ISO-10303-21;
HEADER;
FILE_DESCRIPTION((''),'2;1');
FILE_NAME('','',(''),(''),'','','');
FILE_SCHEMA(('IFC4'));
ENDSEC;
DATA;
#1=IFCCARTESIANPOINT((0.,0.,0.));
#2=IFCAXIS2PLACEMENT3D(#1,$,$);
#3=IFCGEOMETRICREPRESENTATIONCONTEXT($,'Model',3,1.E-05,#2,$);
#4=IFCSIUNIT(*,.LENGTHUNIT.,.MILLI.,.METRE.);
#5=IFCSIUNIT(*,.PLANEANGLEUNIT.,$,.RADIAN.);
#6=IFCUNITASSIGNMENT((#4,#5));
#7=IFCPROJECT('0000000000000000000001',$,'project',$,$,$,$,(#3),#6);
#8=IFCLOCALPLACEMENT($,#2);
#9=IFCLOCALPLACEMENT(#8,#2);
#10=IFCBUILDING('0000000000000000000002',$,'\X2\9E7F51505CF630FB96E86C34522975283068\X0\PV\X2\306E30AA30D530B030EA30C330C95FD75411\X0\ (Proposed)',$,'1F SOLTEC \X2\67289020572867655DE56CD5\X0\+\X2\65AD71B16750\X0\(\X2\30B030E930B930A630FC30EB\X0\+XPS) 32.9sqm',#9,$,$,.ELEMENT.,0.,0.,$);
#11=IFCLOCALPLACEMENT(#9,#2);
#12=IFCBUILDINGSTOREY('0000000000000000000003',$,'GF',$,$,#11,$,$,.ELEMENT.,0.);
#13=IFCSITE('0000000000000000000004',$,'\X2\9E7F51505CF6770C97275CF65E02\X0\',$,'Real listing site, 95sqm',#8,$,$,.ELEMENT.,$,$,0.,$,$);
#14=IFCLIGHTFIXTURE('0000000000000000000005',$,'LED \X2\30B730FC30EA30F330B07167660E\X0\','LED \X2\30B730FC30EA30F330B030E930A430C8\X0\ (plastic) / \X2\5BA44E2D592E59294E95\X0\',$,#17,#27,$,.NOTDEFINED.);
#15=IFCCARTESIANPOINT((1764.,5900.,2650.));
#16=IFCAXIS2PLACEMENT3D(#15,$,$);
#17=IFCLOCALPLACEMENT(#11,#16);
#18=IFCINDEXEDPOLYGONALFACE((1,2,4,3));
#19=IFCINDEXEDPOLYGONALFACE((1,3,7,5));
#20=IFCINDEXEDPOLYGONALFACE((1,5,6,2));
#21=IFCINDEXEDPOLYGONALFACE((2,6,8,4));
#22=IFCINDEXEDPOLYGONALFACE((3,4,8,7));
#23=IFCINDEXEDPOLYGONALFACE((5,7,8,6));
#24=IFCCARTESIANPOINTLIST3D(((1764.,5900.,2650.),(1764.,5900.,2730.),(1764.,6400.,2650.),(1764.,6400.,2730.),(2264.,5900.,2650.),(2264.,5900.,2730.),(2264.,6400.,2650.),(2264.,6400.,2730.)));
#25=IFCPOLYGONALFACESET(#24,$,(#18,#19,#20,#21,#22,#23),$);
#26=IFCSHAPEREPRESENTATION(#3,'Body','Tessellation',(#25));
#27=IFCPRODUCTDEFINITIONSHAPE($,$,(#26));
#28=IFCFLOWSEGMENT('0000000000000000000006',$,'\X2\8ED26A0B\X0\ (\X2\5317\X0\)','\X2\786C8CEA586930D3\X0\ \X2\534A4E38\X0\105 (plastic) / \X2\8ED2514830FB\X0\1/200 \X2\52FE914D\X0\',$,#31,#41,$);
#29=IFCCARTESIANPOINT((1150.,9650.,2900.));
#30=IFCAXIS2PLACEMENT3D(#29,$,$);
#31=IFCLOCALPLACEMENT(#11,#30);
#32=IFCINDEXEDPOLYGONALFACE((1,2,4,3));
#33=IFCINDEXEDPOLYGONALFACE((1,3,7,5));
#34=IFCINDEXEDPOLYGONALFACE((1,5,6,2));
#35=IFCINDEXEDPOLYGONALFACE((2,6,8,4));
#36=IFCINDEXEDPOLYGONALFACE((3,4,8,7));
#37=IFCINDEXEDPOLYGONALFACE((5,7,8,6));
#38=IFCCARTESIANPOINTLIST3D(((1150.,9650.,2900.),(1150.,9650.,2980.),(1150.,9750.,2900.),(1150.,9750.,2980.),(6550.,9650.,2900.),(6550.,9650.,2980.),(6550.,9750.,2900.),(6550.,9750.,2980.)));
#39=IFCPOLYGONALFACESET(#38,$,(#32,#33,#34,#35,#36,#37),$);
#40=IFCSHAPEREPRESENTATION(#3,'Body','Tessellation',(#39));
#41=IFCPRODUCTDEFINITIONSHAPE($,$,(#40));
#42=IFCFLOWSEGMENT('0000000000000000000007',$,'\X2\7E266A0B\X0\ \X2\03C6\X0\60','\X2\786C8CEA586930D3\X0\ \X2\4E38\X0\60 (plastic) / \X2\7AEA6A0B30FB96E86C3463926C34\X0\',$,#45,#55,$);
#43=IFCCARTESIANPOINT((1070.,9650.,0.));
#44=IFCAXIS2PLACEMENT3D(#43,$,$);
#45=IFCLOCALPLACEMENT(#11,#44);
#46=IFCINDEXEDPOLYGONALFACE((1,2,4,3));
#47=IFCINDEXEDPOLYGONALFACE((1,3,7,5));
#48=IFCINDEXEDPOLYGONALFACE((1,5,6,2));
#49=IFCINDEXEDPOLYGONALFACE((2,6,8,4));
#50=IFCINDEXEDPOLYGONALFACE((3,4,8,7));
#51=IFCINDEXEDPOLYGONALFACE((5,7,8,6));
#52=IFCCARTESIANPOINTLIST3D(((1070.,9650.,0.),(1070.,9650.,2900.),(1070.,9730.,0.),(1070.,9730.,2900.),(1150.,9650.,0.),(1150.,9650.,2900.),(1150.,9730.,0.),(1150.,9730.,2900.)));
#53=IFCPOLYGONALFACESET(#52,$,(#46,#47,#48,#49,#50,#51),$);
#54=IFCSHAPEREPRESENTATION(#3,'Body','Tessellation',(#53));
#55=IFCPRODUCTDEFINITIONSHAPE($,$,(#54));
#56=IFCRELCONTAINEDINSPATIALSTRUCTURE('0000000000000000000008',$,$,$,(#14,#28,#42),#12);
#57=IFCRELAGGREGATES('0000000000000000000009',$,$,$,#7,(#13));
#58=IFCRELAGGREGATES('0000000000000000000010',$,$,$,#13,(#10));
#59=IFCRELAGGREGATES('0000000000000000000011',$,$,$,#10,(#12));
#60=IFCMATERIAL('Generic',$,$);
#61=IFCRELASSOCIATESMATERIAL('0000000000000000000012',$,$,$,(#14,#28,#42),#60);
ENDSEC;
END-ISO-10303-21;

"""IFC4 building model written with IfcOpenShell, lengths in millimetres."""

from ifc_helpers import new_model, si_unit, frame, frame_2d, origin, place, context, project, spatial, rectangle, extrude, material, element, save


model = new_model("IFC4")

# Units and contexts
model_context = context("Model", 3, precision=1e-05, world=origin())
ifc_project = project(units=[si_unit("LENGTHUNIT", "METRE", prefix="MILLI"), si_unit("PLANEANGLEUNIT", "RADIAN")], contexts=[model_context])

# Site, building, storey
site_placement = place(None, origin())
site = spatial("IfcSite", under=ifc_project, at=site_placement, Name="鹿児島県霧島市", ObjectType="Real listing site, 95sqm", CompositionType="ELEMENT", RefElevation=0.0)
building_placement = place(site_placement, origin())
building = spatial("IfcBuilding", under=site, at=building_placement, Name="鹿児島・雨水利用とPVのオフグリッド志向 (Proposed)", ObjectType="1F SOLTEC 木造在来工法+断熱材(グラスウール+XPS) 32.9sqm", CompositionType="ELEMENT", ElevationOfRefHeight=0.0, ElevationOfTerrain=0.0)
storey_placement = place(building_placement, origin())
storey = spatial("IfcBuildingStorey", under=building, at=storey_placement, Name="GF", CompositionType="ELEMENT", Elevation=0.0)

# Shared definitions
ifc_material_1 = material(Name="Generic")

# Light fixture
light_fixture_placement = place(storey_placement, frame((1764.0, 5900.0, 2650.0)))
element("IfcLightFixture", 1, at=light_fixture_placement, inside=storey, material=ifc_material_1, Name="LED シーリング照明", Description="LED シーリングライト (plastic) / 室中央天井", PredefinedType="NOTDEFINED", context=model_context, shape_type="SweptSolid", body=[
    extrude(rectangle(XDim=500.0, YDim=500.0, at=frame_2d((250.0, 250.0))), frame((1764.0, 5900.0, 2650.0)), (0.0, 0.0, 1.0), 80.0),
])

# Flow segments
flow_segment_1_placement = place(storey_placement, frame((1150.0, 9650.0, 2900.0)))
element("IfcFlowSegment", 2, at=flow_segment_1_placement, inside=storey, material=ifc_material_1, Name="軒樋 (北)", Description="硬質塩ビ 半丸105 (plastic) / 軒先・1/200 勾配", context=model_context, shape_type="SweptSolid", body=[
    extrude(rectangle(XDim=5400.0, YDim=100.0, at=frame_2d((2700.0, 50.0))), frame((1150.0, 9650.0, 2900.0)), (0.0, 0.0, 1.0), 80.0),
])
flow_segment_2_placement = place(storey_placement, frame((1070.0, 9650.0, 0.0)))
element("IfcFlowSegment", 3, at=flow_segment_2_placement, inside=storey, material=ifc_material_1, Name="縦樋 φ60", Description="硬質塩ビ 丸60 (plastic) / 竪樋・雨水排水", context=model_context, shape_type="SweptSolid", body=[
    extrude(rectangle(XDim=80.0, YDim=80.0, at=frame_2d((40.0, 40.0))), frame((1070.0, 9650.0, 0.0)), (0.0, 0.0, 1.0), 2900.0),
])

save(model, "model.ifc")
